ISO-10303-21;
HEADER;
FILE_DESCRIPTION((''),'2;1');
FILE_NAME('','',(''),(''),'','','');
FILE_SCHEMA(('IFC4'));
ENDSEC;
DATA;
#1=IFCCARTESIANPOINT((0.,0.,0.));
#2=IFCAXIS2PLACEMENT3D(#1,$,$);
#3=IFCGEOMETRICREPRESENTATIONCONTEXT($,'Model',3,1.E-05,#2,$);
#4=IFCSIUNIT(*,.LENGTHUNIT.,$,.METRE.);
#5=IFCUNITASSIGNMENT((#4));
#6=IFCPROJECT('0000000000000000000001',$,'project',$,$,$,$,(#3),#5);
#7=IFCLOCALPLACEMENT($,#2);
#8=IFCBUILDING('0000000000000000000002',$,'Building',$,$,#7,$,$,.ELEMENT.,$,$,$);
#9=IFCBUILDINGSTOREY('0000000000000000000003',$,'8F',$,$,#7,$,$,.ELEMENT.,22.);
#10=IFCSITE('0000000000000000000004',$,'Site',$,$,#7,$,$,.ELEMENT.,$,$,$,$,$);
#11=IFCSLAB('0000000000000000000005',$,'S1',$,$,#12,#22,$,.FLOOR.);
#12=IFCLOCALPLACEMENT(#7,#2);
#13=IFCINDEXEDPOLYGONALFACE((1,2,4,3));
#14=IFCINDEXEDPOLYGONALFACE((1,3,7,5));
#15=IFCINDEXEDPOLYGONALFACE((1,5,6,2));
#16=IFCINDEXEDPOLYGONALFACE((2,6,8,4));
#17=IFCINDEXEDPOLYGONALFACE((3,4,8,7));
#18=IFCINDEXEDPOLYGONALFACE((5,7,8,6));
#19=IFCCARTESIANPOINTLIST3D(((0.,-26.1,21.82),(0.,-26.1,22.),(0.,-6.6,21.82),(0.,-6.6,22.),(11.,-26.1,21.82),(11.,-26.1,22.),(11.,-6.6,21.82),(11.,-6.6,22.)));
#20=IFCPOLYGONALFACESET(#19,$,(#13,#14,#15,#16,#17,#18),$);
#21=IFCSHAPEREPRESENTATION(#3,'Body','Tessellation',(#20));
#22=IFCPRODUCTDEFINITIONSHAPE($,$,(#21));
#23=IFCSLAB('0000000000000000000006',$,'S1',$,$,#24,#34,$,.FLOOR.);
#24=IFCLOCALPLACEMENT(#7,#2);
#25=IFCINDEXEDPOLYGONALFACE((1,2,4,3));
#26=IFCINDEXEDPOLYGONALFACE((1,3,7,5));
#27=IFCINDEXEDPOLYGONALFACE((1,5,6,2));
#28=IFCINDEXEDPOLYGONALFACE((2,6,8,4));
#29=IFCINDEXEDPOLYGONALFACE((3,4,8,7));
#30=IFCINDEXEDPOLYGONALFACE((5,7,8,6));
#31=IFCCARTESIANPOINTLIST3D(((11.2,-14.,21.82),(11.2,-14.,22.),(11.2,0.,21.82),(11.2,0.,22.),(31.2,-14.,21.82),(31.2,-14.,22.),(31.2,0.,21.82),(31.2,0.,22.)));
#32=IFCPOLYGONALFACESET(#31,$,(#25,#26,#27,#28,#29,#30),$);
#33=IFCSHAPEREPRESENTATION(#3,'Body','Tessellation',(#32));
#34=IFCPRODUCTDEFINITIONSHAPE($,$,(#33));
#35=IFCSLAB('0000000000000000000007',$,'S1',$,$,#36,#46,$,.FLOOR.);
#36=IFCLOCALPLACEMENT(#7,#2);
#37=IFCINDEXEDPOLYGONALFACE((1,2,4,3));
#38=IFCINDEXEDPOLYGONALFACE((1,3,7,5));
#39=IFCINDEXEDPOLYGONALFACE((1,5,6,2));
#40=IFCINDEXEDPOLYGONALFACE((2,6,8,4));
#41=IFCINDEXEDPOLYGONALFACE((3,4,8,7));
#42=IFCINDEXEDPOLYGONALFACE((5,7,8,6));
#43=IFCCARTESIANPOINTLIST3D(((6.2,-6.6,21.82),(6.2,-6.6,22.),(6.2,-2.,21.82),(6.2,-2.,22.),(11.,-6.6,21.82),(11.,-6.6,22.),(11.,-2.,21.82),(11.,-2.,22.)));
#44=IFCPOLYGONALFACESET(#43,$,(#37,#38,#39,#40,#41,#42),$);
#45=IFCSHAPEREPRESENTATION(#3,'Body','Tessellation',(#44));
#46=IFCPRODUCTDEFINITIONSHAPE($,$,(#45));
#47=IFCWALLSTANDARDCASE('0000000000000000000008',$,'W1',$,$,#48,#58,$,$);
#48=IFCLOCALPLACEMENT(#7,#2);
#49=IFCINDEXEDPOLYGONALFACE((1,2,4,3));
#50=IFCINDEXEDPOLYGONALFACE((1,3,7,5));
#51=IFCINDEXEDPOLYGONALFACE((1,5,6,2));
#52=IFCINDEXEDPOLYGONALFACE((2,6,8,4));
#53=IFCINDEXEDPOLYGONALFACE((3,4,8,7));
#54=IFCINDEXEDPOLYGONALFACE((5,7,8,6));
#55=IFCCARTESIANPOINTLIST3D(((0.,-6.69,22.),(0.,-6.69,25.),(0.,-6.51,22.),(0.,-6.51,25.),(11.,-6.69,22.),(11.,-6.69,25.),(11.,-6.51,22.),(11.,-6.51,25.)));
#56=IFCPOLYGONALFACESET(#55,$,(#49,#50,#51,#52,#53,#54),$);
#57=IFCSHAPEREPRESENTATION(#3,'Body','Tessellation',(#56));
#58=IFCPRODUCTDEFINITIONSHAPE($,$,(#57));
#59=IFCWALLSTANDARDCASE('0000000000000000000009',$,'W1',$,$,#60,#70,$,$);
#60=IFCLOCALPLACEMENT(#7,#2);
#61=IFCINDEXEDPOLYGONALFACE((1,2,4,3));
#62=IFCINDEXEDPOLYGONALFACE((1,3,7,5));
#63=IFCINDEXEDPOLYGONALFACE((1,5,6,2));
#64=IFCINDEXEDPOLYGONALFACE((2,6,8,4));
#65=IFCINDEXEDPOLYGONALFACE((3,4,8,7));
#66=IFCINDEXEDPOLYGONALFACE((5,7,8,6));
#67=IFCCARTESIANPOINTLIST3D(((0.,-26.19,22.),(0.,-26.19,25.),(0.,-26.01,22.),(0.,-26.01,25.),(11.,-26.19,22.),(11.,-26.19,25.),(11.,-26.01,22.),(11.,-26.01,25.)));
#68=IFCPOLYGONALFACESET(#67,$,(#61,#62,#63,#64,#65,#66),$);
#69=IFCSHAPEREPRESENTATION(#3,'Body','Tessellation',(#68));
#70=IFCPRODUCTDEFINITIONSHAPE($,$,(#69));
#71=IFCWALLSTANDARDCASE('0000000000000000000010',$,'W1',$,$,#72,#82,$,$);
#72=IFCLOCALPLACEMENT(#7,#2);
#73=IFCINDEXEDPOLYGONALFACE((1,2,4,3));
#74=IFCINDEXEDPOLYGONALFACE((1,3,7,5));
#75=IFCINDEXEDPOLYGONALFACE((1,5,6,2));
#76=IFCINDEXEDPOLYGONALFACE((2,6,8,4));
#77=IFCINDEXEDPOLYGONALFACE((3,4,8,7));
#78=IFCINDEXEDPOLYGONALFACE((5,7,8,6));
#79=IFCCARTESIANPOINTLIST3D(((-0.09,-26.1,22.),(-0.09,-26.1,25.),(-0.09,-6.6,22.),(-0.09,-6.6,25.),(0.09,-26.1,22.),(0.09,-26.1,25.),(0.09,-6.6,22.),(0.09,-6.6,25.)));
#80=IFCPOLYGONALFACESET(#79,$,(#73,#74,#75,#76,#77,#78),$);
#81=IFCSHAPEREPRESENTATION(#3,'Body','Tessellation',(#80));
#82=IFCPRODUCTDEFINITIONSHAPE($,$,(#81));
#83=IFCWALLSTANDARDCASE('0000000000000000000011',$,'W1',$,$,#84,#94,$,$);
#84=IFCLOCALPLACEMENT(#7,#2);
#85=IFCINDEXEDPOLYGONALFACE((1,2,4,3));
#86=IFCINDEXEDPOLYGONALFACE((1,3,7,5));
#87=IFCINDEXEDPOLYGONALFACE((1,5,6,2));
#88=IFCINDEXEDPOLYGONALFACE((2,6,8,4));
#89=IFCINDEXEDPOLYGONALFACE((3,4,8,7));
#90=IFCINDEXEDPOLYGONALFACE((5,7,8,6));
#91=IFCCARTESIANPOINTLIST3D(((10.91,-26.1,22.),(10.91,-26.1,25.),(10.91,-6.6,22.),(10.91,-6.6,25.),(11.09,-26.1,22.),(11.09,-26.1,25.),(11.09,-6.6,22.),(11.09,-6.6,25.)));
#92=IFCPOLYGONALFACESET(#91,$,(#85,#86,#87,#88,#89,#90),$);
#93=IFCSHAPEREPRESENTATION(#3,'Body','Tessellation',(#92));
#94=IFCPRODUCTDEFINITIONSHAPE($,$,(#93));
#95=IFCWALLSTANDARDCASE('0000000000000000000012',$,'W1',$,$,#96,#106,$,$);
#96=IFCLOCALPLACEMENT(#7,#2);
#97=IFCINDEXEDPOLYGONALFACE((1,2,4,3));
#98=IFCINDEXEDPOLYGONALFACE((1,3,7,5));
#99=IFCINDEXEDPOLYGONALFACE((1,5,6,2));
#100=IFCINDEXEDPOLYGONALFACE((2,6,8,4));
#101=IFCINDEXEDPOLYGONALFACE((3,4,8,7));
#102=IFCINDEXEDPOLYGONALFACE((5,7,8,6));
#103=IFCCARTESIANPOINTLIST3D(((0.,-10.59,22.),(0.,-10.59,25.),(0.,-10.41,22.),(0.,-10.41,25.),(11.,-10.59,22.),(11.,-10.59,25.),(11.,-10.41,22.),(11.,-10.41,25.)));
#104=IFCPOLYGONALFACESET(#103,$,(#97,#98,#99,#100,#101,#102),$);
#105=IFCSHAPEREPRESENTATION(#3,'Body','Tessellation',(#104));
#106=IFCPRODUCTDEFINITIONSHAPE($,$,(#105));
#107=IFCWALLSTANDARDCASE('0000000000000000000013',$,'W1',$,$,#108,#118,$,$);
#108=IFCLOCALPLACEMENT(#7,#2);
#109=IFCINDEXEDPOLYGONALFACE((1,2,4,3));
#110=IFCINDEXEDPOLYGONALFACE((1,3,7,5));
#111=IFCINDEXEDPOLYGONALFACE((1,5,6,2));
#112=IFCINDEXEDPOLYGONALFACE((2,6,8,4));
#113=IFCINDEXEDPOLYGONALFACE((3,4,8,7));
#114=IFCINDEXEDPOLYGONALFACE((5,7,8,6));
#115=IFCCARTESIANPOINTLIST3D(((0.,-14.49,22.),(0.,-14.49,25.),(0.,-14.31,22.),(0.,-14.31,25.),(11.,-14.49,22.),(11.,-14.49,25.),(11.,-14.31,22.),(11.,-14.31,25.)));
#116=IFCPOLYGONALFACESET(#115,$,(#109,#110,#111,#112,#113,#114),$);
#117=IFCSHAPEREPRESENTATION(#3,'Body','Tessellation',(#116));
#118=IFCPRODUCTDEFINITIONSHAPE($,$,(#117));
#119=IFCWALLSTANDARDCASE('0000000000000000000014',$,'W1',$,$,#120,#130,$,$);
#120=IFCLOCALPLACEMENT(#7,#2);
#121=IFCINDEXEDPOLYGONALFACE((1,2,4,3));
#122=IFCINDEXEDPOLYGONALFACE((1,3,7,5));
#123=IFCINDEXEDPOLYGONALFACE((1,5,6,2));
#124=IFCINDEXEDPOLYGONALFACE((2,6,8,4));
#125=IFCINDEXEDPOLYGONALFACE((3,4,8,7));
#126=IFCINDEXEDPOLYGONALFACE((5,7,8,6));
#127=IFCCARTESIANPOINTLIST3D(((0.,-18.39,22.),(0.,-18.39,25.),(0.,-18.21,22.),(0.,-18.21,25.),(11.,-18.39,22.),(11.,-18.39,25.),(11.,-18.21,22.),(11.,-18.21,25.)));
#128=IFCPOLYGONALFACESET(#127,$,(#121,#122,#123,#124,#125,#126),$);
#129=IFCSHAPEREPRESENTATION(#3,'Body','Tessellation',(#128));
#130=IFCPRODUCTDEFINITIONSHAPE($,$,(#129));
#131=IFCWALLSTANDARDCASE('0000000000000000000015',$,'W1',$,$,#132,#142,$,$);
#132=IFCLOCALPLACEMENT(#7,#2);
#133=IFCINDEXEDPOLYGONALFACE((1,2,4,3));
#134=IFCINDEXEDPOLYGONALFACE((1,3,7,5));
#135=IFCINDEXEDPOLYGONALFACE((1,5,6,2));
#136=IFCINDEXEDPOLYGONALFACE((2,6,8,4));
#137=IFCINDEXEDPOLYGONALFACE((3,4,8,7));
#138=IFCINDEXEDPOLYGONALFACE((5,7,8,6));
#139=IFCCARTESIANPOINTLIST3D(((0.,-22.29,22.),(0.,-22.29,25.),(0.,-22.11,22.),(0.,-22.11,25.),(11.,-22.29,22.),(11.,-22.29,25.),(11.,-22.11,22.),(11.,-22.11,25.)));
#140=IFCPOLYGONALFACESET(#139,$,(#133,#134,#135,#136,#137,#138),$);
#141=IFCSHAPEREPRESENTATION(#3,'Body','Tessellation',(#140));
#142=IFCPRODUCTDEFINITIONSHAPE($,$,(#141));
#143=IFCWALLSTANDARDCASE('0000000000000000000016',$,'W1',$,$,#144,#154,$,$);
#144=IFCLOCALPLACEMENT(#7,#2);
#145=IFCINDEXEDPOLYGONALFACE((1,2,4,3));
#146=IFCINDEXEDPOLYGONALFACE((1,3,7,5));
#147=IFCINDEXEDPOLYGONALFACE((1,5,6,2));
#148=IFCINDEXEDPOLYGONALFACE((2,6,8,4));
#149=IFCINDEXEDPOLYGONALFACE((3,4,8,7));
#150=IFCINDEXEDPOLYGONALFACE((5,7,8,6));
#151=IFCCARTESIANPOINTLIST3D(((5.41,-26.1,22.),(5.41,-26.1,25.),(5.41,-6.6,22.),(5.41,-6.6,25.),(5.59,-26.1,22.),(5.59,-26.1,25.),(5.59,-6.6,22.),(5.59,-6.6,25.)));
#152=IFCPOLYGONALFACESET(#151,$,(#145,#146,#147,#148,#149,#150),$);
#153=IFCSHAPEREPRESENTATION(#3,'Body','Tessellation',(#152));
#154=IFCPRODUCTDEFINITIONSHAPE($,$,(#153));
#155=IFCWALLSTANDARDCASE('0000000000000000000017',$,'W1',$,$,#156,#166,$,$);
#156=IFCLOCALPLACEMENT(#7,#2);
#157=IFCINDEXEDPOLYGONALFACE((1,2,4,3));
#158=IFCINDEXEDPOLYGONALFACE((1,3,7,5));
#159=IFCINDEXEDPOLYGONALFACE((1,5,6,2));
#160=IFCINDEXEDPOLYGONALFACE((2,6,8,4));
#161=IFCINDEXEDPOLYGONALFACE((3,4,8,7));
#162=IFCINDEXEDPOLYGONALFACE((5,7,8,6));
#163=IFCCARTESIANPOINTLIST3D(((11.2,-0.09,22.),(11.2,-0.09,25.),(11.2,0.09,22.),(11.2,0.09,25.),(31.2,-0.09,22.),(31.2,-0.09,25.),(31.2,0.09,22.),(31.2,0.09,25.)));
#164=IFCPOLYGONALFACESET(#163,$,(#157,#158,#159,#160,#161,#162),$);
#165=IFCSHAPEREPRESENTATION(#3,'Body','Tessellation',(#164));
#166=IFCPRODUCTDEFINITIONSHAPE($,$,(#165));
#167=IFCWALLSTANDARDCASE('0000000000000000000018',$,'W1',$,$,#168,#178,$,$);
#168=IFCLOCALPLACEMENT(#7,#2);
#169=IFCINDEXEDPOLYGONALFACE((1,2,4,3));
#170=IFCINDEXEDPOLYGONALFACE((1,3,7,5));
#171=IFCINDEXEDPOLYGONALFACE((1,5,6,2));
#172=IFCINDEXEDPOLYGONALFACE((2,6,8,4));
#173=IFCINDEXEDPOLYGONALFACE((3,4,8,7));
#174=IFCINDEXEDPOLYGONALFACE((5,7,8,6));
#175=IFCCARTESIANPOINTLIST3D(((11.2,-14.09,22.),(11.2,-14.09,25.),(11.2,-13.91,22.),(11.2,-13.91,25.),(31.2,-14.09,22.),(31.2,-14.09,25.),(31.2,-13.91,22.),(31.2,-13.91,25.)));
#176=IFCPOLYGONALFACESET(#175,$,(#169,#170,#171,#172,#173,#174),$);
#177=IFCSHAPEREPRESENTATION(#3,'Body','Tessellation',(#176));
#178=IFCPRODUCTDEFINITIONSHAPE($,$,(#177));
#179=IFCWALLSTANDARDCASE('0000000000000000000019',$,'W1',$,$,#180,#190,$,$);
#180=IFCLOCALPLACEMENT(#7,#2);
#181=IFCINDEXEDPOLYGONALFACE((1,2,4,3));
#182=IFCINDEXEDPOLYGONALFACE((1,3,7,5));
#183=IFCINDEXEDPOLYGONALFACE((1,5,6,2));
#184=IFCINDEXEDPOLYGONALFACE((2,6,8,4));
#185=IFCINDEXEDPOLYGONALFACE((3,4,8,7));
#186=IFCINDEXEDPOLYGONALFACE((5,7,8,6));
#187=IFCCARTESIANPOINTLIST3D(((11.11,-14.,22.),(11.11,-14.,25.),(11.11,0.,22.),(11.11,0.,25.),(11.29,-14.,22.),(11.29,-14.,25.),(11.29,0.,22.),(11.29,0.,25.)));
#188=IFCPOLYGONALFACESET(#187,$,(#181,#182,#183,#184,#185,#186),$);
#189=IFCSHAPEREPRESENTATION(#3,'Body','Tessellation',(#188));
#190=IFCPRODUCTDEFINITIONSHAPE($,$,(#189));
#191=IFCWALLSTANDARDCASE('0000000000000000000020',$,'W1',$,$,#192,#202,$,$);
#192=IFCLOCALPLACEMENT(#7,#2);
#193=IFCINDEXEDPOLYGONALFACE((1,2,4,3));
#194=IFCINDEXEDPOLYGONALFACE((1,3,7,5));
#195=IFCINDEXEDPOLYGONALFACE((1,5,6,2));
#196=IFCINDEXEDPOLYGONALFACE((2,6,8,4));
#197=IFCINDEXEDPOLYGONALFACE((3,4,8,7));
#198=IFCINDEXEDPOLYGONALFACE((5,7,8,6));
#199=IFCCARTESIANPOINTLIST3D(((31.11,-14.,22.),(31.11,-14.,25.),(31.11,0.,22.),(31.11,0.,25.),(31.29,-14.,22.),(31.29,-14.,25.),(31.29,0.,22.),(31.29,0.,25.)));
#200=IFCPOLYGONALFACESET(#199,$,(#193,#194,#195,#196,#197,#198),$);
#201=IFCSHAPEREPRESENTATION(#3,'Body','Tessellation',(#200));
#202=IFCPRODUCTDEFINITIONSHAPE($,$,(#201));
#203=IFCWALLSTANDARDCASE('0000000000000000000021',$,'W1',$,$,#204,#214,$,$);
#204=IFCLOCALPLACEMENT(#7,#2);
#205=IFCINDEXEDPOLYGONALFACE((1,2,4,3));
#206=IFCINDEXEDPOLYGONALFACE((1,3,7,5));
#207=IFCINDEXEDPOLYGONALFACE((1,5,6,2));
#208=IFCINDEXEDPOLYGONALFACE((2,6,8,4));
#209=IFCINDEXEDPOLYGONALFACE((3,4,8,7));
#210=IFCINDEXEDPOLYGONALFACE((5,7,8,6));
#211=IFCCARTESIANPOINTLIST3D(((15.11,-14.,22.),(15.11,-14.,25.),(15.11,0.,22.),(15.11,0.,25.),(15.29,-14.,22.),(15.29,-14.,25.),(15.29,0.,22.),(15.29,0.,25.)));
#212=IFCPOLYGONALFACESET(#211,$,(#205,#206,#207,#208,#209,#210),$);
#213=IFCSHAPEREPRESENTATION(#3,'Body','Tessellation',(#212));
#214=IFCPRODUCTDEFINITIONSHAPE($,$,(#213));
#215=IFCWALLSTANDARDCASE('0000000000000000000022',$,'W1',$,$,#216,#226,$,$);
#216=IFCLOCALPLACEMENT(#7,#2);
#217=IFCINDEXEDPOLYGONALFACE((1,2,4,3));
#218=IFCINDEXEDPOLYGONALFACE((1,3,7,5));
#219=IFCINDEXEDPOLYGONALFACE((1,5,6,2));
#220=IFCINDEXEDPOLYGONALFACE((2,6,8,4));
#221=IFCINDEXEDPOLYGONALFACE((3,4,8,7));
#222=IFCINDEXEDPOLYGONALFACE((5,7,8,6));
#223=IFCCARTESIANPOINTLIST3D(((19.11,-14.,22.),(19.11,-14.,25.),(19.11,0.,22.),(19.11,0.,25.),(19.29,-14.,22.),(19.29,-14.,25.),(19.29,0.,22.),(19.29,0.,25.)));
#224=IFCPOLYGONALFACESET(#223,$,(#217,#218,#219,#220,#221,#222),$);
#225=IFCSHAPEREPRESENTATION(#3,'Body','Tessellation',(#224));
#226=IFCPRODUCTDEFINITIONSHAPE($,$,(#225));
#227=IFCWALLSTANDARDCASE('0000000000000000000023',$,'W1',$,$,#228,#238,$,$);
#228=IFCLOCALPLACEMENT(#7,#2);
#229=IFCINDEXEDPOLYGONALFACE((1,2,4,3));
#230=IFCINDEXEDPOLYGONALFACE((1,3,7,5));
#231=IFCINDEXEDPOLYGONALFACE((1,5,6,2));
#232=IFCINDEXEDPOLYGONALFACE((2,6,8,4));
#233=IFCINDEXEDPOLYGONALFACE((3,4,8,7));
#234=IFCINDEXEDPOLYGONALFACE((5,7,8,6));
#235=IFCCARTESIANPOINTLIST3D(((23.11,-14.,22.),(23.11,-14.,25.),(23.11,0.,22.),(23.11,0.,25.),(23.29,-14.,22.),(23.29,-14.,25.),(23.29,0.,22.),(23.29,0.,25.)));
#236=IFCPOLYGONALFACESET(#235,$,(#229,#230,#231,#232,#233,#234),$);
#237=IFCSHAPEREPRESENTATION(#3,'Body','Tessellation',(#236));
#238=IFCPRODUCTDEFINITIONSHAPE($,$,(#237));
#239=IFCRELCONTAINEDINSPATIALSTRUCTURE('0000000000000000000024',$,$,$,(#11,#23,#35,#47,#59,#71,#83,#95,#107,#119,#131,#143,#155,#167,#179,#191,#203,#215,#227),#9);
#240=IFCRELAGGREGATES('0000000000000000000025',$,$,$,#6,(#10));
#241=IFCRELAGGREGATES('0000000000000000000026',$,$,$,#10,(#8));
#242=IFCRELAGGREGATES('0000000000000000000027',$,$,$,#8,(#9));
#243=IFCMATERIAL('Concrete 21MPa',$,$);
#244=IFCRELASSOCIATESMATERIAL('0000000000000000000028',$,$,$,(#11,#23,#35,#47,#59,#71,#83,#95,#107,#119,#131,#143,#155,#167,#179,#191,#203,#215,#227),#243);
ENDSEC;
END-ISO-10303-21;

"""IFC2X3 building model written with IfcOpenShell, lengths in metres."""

from ifc_helpers import new_model, si_unit, frame, origin, origin_2d, place, context, project, spatial, rectangle, extrude, material, element, save


model = new_model("IFC2X3")

# Units and contexts
model_context = context("Model", 3, precision=1e-05, world=origin())
ifc_project = project(units=[si_unit("LENGTHUNIT", "METRE")], contexts=[model_context])

# Site, building, storey
placement = place(None, origin())
site = spatial("IfcSite", under=ifc_project, at=placement, Name="Site", CompositionType="ELEMENT")
building = spatial("IfcBuilding", under=site, at=placement, Name="Building", CompositionType="ELEMENT")
storey = spatial("IfcBuildingStorey", under=building, at=placement, Name="8F", CompositionType="ELEMENT", Elevation=22.0)

# Slabs
ifc_material_1 = material(Name="Concrete 21MPa")
slab_1_placement = place(None, frame((5.5, -16.35, 21.82)))
element("IfcSlab", 1, at=slab_1_placement, inside=storey, material=ifc_material_1, Name="S1", PredefinedType="FLOOR", context=model_context, shape_type="SweptSolid", body=[
    extrude(rectangle(XDim=11.0, YDim=19.5, at=origin_2d()), origin(), (0.0, 0.0, 1.0), 0.18),
])
slab_2_placement = place(None, frame((21.2, -7.0, 21.82)))
element("IfcSlab", 2, at=slab_2_placement, inside=storey, material=ifc_material_1, Name="S1", PredefinedType="FLOOR", context=model_context, shape_type="SweptSolid", body=[
    extrude(rectangle(XDim=20.0, YDim=14.0, at=origin_2d()), origin(), (0.0, 0.0, 1.0), 0.18),
])
slab_3_placement = place(None, frame((8.6, -4.3, 21.82)))
element("IfcSlab", 3, at=slab_3_placement, inside=storey, material=ifc_material_1, Name="S1", PredefinedType="FLOOR", context=model_context, shape_type="SweptSolid", body=[
    extrude(rectangle(XDim=4.8, YDim=4.6, at=origin_2d()), origin(), (0.0, 0.0, 1.0), 0.18),
])

# Walls
for number, where, name in (
    (4, (5.5, -6.6, 22.0), "W1"),
    (5, (5.5, -26.1, 22.0), "W1"),
):
    element("IfcWallStandardCase", number, at=place(None, frame(where)), inside=storey, material=ifc_material_1, Name=name, context=model_context, shape_type="SweptSolid", body=[
        extrude(rectangle(XDim=11.0, YDim=0.18, at=origin_2d()), origin(), (0.0, 0.0, 1.0), 3.0),
    ])
for number, where, name in (
    (6, (0.0, -16.35, 22.0), "W1"),
    (7, (11.0, -16.35, 22.0), "W1"),
):
    element("IfcWallStandardCase", number, at=place(None, frame(where)), inside=storey, material=ifc_material_1, Name=name, context=model_context, shape_type="SweptSolid", body=[
        extrude(rectangle(XDim=0.18, YDim=19.5, at=origin_2d()), origin(), (0.0, 0.0, 1.0), 3.0),
    ])
for number, where, name in (
    (8, (5.5, -10.5, 22.0), "W1"),
    (9, (5.5, -14.4, 22.0), "W1"),
    (10, (5.5, -18.3, 22.0), "W1"),
    (11, (5.5, -22.2, 22.0), "W1"),
):
    element("IfcWallStandardCase", number, at=place(None, frame(where)), inside=storey, material=ifc_material_1, Name=name, context=model_context, shape_type="SweptSolid", body=[
        extrude(rectangle(XDim=11.0, YDim=0.18, at=origin_2d()), origin(), (0.0, 0.0, 1.0), 3.0),
    ])
wall_1_placement = place(None, frame((5.5, -16.35, 22.0)))
element("IfcWallStandardCase", 12, at=wall_1_placement, inside=storey, material=ifc_material_1, Name="W1", context=model_context, shape_type="SweptSolid", body=[
    extrude(rectangle(XDim=0.18, YDim=19.5, at=origin_2d()), origin(), (0.0, 0.0, 1.0), 3.0),
])
for number, where, name in (
    (13, (21.2, 0.0, 22.0), "W1"),
    (14, (21.2, -14.0, 22.0), "W1"),
):
    element("IfcWallStandardCase", number, at=place(None, frame(where)), inside=storey, material=ifc_material_1, Name=name, context=model_context, shape_type="SweptSolid", body=[
        extrude(rectangle(XDim=20.0, YDim=0.18, at=origin_2d()), origin(), (0.0, 0.0, 1.0), 3.0),
    ])
for number, where, name in (
    (15, (11.2, -7.0, 22.0), "W1"),
    (16, (31.2, -7.0, 22.0), "W1"),
    (17, (15.2, -7.0, 22.0), "W1"),
    (18, (19.2, -7.0, 22.0), "W1"),
    (19, (23.2, -7.0, 22.0), "W1"),
):
    element("IfcWallStandardCase", number, at=place(None, frame(where)), inside=storey, material=ifc_material_1, Name=name, context=model_context, shape_type="SweptSolid", body=[
        extrude(rectangle(XDim=0.18, YDim=14.0, at=origin_2d()), origin(), (0.0, 0.0, 1.0), 3.0),
    ])

save(model, "model.ifc")
